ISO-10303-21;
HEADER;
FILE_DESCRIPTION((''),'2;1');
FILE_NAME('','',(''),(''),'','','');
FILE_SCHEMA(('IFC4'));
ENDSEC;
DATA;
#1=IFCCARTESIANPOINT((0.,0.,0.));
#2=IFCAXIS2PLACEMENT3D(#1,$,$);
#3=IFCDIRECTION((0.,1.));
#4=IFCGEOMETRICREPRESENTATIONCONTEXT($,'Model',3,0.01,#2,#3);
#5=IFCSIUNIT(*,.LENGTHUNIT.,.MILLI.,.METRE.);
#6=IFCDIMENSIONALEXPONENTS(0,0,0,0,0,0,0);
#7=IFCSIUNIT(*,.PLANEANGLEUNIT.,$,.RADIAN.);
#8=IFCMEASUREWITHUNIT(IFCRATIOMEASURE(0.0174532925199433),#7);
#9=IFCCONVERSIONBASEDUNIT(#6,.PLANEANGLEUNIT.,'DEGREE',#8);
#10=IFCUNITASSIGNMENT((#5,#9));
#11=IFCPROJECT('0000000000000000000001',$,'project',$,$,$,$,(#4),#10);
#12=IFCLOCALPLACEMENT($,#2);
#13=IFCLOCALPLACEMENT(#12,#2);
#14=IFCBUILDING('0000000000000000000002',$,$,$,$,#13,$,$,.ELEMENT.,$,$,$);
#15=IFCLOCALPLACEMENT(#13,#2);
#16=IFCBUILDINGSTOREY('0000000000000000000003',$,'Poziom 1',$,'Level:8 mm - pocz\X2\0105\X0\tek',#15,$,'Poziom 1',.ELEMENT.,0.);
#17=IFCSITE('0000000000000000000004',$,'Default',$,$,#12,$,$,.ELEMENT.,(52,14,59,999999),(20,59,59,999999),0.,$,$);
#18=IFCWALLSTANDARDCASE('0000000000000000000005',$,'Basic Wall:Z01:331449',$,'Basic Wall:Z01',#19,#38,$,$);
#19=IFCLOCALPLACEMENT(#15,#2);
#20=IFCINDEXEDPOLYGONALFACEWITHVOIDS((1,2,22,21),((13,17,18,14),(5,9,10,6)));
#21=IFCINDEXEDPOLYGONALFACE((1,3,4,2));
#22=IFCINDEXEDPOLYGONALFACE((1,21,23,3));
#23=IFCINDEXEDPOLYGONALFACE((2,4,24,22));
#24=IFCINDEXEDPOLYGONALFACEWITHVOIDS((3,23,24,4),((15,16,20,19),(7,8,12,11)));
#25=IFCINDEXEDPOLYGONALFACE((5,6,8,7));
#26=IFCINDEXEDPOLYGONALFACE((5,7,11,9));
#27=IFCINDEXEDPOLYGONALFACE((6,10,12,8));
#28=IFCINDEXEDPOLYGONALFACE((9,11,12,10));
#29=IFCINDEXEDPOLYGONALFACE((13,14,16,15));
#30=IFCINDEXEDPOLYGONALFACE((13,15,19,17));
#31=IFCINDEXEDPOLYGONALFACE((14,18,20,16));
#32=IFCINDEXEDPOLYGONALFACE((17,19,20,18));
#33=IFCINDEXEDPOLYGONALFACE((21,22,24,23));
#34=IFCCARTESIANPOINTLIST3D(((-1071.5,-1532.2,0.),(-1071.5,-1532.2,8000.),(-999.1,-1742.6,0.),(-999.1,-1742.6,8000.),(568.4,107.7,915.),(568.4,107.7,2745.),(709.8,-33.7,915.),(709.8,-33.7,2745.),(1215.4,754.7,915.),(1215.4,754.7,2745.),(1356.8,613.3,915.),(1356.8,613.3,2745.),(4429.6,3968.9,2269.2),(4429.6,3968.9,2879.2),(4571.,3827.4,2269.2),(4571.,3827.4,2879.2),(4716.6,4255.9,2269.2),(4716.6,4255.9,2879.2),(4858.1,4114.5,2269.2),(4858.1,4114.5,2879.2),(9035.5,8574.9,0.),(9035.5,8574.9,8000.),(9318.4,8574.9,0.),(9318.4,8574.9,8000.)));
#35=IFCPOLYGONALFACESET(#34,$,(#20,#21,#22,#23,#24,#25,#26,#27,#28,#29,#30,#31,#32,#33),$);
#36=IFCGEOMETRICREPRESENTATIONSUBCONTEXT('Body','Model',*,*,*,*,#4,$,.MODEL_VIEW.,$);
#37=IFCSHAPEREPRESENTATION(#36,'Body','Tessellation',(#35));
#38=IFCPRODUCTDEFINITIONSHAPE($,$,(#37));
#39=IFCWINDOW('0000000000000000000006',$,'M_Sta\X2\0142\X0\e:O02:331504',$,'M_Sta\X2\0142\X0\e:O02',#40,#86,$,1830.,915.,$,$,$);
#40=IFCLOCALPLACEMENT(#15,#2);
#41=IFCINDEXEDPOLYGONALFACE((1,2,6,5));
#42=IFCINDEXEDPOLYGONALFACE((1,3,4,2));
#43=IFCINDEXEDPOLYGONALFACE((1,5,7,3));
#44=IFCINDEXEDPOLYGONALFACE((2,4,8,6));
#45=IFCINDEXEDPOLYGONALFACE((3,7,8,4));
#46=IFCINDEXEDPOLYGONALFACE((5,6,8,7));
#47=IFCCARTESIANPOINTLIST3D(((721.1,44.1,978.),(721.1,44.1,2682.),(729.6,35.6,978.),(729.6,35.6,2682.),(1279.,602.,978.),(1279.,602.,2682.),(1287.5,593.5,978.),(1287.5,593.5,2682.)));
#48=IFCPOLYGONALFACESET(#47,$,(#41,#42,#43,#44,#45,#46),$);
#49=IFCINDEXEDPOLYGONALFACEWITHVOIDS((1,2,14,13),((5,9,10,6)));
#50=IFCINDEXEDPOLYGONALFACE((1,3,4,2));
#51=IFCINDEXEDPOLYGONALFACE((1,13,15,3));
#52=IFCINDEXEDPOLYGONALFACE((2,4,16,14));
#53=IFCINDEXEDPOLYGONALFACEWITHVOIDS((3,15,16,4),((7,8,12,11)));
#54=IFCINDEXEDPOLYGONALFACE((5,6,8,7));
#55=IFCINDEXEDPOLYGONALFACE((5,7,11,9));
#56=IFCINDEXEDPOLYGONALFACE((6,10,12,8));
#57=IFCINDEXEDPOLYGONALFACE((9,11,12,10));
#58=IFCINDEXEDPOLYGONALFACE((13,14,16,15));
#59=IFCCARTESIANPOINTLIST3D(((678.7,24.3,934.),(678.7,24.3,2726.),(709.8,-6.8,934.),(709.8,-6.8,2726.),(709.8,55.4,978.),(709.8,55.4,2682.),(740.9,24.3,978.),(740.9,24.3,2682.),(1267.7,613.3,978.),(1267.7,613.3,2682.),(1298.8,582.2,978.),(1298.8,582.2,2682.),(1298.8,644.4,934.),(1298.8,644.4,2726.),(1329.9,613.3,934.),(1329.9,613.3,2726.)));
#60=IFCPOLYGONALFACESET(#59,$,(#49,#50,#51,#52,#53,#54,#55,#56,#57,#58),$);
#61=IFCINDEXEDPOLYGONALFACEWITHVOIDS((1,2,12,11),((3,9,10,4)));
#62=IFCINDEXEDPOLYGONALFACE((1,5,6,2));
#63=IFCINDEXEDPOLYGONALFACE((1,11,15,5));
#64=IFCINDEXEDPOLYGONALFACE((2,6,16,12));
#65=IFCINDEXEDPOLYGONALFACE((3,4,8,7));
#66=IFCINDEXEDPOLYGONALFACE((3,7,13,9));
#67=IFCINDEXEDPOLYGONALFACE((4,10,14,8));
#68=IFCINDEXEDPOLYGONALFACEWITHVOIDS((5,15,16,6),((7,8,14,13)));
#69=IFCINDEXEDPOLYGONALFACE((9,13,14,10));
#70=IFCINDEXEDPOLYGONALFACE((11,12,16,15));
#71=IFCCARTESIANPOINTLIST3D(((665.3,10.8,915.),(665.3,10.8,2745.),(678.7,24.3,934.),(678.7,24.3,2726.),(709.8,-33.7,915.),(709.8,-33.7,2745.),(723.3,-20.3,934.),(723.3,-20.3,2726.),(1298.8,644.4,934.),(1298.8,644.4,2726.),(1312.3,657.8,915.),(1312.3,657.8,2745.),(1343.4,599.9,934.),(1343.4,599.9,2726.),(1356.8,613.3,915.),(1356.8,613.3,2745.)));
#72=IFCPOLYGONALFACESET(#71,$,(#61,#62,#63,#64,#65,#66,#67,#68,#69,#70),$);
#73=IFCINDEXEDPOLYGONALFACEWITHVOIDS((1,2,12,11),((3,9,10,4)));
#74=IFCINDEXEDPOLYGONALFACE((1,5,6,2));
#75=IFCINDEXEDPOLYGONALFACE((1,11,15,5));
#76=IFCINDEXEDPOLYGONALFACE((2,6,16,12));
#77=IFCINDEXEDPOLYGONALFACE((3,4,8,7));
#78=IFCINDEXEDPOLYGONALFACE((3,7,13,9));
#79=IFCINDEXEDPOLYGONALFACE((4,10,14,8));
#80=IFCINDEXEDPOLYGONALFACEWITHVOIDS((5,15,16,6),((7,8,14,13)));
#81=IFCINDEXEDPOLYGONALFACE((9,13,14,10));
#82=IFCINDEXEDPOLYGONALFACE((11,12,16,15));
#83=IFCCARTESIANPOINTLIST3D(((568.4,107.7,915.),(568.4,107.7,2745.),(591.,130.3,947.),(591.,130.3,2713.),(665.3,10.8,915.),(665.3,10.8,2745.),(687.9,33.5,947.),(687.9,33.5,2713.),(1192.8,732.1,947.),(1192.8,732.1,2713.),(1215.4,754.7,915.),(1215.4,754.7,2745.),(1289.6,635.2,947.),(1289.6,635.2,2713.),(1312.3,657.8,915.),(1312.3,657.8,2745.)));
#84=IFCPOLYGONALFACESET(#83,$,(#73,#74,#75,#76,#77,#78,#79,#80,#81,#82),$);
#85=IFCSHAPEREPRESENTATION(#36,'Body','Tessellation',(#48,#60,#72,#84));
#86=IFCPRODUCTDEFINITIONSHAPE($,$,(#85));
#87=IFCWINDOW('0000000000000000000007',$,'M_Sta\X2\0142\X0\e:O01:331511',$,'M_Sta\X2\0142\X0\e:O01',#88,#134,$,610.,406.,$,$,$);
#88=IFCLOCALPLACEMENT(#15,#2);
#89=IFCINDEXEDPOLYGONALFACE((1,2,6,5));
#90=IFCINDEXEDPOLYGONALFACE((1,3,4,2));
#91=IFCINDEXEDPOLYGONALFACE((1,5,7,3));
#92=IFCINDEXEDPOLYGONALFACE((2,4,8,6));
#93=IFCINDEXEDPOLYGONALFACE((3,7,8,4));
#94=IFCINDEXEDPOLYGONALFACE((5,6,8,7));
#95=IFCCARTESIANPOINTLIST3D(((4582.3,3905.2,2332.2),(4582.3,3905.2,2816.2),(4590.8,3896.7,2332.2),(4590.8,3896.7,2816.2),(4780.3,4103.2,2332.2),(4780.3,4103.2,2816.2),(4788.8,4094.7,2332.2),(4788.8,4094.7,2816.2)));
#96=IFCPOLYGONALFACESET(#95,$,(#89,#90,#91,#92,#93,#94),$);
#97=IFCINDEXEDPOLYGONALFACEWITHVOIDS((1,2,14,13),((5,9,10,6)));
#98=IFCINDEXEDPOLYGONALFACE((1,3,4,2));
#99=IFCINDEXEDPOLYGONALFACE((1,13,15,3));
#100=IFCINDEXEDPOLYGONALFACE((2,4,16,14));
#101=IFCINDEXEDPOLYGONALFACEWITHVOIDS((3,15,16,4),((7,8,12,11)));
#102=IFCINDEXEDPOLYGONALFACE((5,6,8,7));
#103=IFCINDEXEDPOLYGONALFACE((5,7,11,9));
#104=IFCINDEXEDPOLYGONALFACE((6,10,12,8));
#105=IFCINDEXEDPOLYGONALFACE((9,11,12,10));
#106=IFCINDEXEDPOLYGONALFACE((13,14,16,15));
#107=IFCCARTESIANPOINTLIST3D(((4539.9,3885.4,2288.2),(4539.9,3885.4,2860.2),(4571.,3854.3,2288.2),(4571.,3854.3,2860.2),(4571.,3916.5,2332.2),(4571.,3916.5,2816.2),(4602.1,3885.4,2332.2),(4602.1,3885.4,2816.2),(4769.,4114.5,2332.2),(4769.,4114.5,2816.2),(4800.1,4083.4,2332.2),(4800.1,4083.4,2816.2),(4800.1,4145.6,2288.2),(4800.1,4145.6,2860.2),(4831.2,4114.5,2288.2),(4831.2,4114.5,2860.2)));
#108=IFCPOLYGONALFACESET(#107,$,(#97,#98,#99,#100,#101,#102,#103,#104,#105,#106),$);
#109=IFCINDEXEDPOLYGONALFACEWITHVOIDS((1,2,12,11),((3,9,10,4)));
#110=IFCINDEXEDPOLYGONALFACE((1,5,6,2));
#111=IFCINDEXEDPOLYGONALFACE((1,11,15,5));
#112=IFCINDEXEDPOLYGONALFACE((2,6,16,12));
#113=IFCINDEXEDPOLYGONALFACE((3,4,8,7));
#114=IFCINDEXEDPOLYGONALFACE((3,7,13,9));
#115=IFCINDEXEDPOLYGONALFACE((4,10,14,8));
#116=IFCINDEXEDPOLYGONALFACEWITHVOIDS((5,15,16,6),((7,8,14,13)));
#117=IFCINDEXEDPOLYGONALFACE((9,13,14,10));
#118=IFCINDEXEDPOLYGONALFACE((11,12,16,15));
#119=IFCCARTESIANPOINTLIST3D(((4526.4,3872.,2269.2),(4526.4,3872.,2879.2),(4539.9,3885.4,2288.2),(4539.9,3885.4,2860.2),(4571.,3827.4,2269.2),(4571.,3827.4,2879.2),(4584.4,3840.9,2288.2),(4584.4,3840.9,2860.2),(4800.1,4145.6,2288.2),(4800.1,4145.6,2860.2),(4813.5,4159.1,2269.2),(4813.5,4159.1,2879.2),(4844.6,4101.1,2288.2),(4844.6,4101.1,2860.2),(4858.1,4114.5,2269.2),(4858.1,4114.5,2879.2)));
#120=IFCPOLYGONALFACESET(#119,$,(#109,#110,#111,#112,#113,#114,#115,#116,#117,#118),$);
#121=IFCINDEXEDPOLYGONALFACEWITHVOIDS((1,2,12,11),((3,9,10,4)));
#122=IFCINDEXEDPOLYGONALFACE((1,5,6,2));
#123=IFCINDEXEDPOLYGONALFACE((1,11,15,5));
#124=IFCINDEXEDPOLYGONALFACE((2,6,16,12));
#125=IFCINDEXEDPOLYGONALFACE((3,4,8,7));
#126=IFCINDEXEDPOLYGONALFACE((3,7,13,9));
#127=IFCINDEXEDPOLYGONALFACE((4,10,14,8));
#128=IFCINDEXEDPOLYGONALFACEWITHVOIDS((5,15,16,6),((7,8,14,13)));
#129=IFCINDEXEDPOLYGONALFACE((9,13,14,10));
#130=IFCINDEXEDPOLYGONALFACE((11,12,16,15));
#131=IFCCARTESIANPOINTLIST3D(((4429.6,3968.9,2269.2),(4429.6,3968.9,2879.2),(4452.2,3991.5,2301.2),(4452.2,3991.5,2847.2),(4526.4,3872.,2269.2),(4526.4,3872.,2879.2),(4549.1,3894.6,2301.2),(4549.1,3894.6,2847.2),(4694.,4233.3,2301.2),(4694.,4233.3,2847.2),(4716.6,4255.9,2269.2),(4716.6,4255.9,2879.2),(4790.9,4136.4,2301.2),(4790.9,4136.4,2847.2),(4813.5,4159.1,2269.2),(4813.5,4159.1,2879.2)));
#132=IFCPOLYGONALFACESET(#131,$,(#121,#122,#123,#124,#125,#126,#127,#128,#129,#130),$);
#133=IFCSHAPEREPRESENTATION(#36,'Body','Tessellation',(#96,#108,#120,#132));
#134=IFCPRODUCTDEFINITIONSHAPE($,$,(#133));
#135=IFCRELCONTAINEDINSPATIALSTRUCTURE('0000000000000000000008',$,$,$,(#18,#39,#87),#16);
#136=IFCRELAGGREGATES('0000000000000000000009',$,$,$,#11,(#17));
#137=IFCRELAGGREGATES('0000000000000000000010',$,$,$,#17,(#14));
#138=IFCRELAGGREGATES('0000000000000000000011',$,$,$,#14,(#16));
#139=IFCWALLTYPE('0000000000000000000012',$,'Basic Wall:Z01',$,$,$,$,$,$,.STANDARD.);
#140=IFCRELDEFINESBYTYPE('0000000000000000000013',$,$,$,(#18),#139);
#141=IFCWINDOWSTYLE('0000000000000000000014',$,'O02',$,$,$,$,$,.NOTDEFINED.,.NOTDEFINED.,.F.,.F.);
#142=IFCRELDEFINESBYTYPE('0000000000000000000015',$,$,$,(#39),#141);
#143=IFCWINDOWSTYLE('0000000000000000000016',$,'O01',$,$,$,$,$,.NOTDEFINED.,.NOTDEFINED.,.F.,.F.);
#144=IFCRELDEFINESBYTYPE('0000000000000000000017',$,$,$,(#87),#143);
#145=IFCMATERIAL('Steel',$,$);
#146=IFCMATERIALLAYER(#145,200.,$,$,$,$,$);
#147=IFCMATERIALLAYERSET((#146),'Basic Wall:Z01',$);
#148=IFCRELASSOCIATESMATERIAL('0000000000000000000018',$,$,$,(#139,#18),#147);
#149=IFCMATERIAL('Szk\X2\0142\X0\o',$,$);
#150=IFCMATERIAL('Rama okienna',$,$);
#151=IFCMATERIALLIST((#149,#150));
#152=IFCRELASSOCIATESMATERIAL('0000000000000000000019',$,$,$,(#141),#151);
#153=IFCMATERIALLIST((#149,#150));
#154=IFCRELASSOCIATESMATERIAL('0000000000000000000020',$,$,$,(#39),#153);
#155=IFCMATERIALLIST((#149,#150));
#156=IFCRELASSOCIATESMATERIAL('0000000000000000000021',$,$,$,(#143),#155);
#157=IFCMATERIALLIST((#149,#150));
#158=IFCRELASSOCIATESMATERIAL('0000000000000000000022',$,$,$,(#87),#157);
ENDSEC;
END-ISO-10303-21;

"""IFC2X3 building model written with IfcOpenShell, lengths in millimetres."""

from ifc_helpers import new_model, entity, si_unit, converted_unit, direction, frame, frame_2d, origin, place, context, subcontext, project, spatial, polyline, rectangle, outline, extrude, source, transform, mapped, material, material_list, layer, layer_set, layer_usage, type_object, type_shapes, element, fill, save


model = new_model("IFC2X3")

# Units and contexts
model_context = context("Model", 3, precision=0.01, world=origin(), true_north=direction((0.0, 1.0)))
body_context = subcontext(model_context, "Body", "Model", "MODEL_VIEW")
ifc_project = project(units=[si_unit("LENGTHUNIT", "METRE", prefix="MILLI"), converted_unit("PLANEANGLEUNIT", "DEGREE", entity("IfcRatioMeasure", 0.0174532925199433), si_unit("PLANEANGLEUNIT", "RADIAN"), dimensions=[0, 0, 0, 0, 0, 0, 0])], contexts=[model_context])

# Site, building, storey
site_placement = place(None, origin())
site = spatial("IfcSite", under=ifc_project, at=site_placement, Name="Default", CompositionType="ELEMENT", RefLatitude=(52, 14, 59, 999999), RefLongitude=(20, 59, 59, 999999), RefElevation=0.0)
building_placement = place(site_placement, origin())
building = spatial("IfcBuilding", under=site, at=building_placement, CompositionType="ELEMENT")
storey_placement = place(building_placement, origin())
storey = spatial("IfcBuildingStorey", under=building, at=storey_placement, Name="Poziom 1", ObjectType="Level:8 mm - początek", LongName="Poziom 1", CompositionType="ELEMENT", Elevation=0.0)

# Shared definitions
ifc_material_1 = material(Name="Steel")
ifc_layer_1 = layer(ifc_material_1, 200.0)
ifc_layer_set_1 = layer_set([ifc_layer_1], Name="Basic Wall:Z01")
wall_type_1 = type_object("IfcWallType", Name="Basic Wall:Z01", PredefinedType="STANDARD", material=ifc_layer_set_1)

# Wall, openings, windows
ifc_layer_usage_1 = layer_usage(ifc_layer_set_1, "AXIS2", "NEGATIVE", 100.0)
wall_1_placement = place(storey_placement, frame((-1069.8, -1671.9, 0.0), z_axis=(0.0, 0.0, 1.0), x_axis=(0.707107, 0.707107, 0.0)))
wall_1 = element("IfcWallStandardCase", 1, at=wall_1_placement, inside=storey, type_object=wall_type_1, material=ifc_layer_usage_1, Name="Basic Wall:Z01:331449", ObjectType="Basic Wall:Z01", context=body_context, shape_type="SweptSolid", body=[
    extrude(outline(polyline([(14591.1, -100.0), (14391.1, 100.0), (13684.0, 100.0), (97.5, 100.0), (0.0, -100.0), (14591.1, -100.0)])), origin(), (0.0, 0.0, 1.0), 8000.0),
])
opening_1_placement = place(wall_1_placement, frame((3331.7, 100.0, 915.0)))
opening_1 = element("IfcOpeningElement", 2, at=opening_1_placement, cuts=wall_1, ObjectType="Opening", context=body_context, shape_type="SweptSolid", body=[
    extrude(rectangle(XDim=1830.0, YDim=915.0, at=frame_2d((915.0, 457.5), x_axis=(1.0, 0.0))), frame((0.0, 0.0, 0.0), z_axis=(0.0, -1.0, 0.0), x_axis=(0.0, 0.0, 1.0)), (0.0, 0.0, 1.0), 200.0),
])
opening_2_placement = place(wall_1_placement, frame((8283.2, 100.0, 2269.2)))
opening_2 = element("IfcOpeningElement", 3, at=opening_2_placement, cuts=wall_1, ObjectType="Opening", context=body_context, shape_type="SweptSolid", body=[
    extrude(rectangle(XDim=610.0, YDim=406.0, at=frame_2d((305.0, 203.0), x_axis=(1.0, 0.0))), frame((0.0, 0.0, 0.0), z_axis=(0.0, -1.0, 0.0), x_axis=(0.0, 0.0, 1.0)), (0.0, 0.0, 1.0), 200.0),
])
ifc_material_2 = material(Name="Szkło")
ifc_material_3 = material(Name="Rama okienna")
ifc_material_list_1 = material_list([ifc_material_2, ifc_material_3])
ifc_material_list_2 = material_list([ifc_material_2, ifc_material_3])
window_style_1 = type_object("IfcWindowStyle", Name="O02", ConstructionType="NOTDEFINED", OperationType="NOTDEFINED", ParameterTakesPrecedence=False, Sizeable=False, material=ifc_material_list_2)
shared_shape_1 = source(origin(), body_context, "Body", "SweptSolid", [
    extrude(rectangle(XDim=12.0, YDim=789.0, at=frame_2d((0.0, 0.0), x_axis=(1.0, 0.0))), frame((457.5, 159.0, 63.0), z_axis=(0.0, 0.0, 1.0), x_axis=(0.0, -1.0, 0.0)), (0.0, 0.0, 1.0), 1704.0),
    extrude(outline(polyline([(-438.5, -896.0), (438.5, -896.0), (438.5, 896.0), (-438.5, 896.0), (-438.5, -896.0)]), holes=[polyline([(-394.5, -852.0), (-394.5, 852.0), (394.5, 852.0), (394.5, -852.0), (-394.5, -852.0)])]), frame((457.5, 137.0, 915.0), z_axis=(0.0, 1.0, 0.0), x_axis=(1.0, 0.0, 0.0)), (0.0, 0.0, 1.0), 44.0),
    extrude(outline(polyline([(-457.5, -915.0), (457.5, -915.0), (457.5, 915.0), (-457.5, 915.0), (-457.5, -915.0)]), holes=[polyline([(-438.5, -896.0), (-438.5, 896.0), (438.5, 896.0), (438.5, -896.0), (-438.5, -896.0)])]), frame((457.5, 137.0, 915.0), z_axis=(0.0, 1.0, 0.0), x_axis=(1.0, 0.0, 0.0)), (0.0, 0.0, 1.0), 63.0),
    extrude(outline(polyline([(-457.5, -915.0), (457.5, -915.0), (457.5, 915.0), (-457.5, 915.0), (-457.5, -915.0)]), holes=[polyline([(-425.5, -883.0), (-425.5, 883.0), (425.5, 883.0), (425.5, -883.0), (-425.5, -883.0)])]), frame((457.5, 0.0, 915.0), z_axis=(0.0, 1.0, 0.0), x_axis=(1.0, 0.0, 0.0)), (0.0, 0.0, 1.0), 137.0),
])
type_shapes(window_style_1, [shared_shape_1])
window_1_placement = place(opening_1_placement, frame((0.0, 0.0, 0.0), z_axis=(0.0, 0.0, 1.0), x_axis=(-1.0, 0.0, 0.0)))
window_1 = element("IfcWindow", 4, at=window_1_placement, inside=storey, type_object=window_style_1, material=ifc_material_list_1, Name="M_Stałe:O02:331504", ObjectType="M_Stałe:O02", OverallHeight=1830.0, OverallWidth=915.0, context=body_context, shape_type="MappedRepresentation", body=[
    mapped(shared_shape_1, transform((0.0, 0.0, 0.0), scale=1.0)),
])
fill(opening_1, window_1)
ifc_material_list_3 = material_list([ifc_material_2, ifc_material_3])
ifc_material_list_4 = material_list([ifc_material_2, ifc_material_3])
window_style_2 = type_object("IfcWindowStyle", Name="O01", ConstructionType="NOTDEFINED", OperationType="NOTDEFINED", ParameterTakesPrecedence=False, Sizeable=False, material=ifc_material_list_4)
shared_shape_2 = source(origin(), body_context, "Body", "SweptSolid", [
    extrude(rectangle(XDim=12.0, YDim=280.0, at=frame_2d((0.0, 0.0), x_axis=(1.0, 0.0))), frame((203.0, 159.0, 63.0), z_axis=(0.0, 0.0, 1.0), x_axis=(0.0, -1.0, 0.0)), (0.0, 0.0, 1.0), 484.0),
    extrude(outline(polyline([(-184.0, -286.0), (184.0, -286.0), (184.0, 286.0), (-184.0, 286.0), (-184.0, -286.0)]), holes=[polyline([(-140.0, -242.0), (-140.0, 242.0), (140.0, 242.0), (140.0, -242.0), (-140.0, -242.0)])]), frame((203.0, 137.0, 305.0), z_axis=(0.0, 1.0, 0.0), x_axis=(1.0, 0.0, 0.0)), (0.0, 0.0, 1.0), 44.0),
    extrude(outline(polyline([(-203.0, -305.0), (203.0, -305.0), (203.0, 305.0), (-203.0, 305.0), (-203.0, -305.0)]), holes=[polyline([(-184.0, -286.0), (-184.0, 286.0), (184.0, 286.0), (184.0, -286.0), (-184.0, -286.0)])]), frame((203.0, 137.0, 305.0), z_axis=(0.0, 1.0, 0.0), x_axis=(1.0, 0.0, 0.0)), (0.0, 0.0, 1.0), 63.0),
    extrude(outline(polyline([(-203.0, -305.0), (203.0, -305.0), (203.0, 305.0), (-203.0, 305.0), (-203.0, -305.0)]), holes=[polyline([(-171.0, -273.0), (-171.0, 273.0), (171.0, 273.0), (171.0, -273.0), (-171.0, -273.0)])]), frame((203.0, 0.0, 305.0), z_axis=(0.0, 1.0, 0.0), x_axis=(1.0, 0.0, 0.0)), (0.0, 0.0, 1.0), 137.0),
])
type_shapes(window_style_2, [shared_shape_2])
window_2_placement = place(opening_2_placement, frame((0.0, 0.0, 0.0), z_axis=(0.0, 0.0, 1.0), x_axis=(-1.0, 0.0, 0.0)))
window_2 = element("IfcWindow", 5, at=window_2_placement, inside=storey, type_object=window_style_2, material=ifc_material_list_3, Name="M_Stałe:O01:331511", ObjectType="M_Stałe:O01", OverallHeight=610.0, OverallWidth=406.0, context=body_context, shape_type="MappedRepresentation", body=[
    mapped(shared_shape_2, transform((0.0, 0.0, 0.0), scale=1.0)),
])
fill(opening_2, window_2)

save(model, "model.ifc")
